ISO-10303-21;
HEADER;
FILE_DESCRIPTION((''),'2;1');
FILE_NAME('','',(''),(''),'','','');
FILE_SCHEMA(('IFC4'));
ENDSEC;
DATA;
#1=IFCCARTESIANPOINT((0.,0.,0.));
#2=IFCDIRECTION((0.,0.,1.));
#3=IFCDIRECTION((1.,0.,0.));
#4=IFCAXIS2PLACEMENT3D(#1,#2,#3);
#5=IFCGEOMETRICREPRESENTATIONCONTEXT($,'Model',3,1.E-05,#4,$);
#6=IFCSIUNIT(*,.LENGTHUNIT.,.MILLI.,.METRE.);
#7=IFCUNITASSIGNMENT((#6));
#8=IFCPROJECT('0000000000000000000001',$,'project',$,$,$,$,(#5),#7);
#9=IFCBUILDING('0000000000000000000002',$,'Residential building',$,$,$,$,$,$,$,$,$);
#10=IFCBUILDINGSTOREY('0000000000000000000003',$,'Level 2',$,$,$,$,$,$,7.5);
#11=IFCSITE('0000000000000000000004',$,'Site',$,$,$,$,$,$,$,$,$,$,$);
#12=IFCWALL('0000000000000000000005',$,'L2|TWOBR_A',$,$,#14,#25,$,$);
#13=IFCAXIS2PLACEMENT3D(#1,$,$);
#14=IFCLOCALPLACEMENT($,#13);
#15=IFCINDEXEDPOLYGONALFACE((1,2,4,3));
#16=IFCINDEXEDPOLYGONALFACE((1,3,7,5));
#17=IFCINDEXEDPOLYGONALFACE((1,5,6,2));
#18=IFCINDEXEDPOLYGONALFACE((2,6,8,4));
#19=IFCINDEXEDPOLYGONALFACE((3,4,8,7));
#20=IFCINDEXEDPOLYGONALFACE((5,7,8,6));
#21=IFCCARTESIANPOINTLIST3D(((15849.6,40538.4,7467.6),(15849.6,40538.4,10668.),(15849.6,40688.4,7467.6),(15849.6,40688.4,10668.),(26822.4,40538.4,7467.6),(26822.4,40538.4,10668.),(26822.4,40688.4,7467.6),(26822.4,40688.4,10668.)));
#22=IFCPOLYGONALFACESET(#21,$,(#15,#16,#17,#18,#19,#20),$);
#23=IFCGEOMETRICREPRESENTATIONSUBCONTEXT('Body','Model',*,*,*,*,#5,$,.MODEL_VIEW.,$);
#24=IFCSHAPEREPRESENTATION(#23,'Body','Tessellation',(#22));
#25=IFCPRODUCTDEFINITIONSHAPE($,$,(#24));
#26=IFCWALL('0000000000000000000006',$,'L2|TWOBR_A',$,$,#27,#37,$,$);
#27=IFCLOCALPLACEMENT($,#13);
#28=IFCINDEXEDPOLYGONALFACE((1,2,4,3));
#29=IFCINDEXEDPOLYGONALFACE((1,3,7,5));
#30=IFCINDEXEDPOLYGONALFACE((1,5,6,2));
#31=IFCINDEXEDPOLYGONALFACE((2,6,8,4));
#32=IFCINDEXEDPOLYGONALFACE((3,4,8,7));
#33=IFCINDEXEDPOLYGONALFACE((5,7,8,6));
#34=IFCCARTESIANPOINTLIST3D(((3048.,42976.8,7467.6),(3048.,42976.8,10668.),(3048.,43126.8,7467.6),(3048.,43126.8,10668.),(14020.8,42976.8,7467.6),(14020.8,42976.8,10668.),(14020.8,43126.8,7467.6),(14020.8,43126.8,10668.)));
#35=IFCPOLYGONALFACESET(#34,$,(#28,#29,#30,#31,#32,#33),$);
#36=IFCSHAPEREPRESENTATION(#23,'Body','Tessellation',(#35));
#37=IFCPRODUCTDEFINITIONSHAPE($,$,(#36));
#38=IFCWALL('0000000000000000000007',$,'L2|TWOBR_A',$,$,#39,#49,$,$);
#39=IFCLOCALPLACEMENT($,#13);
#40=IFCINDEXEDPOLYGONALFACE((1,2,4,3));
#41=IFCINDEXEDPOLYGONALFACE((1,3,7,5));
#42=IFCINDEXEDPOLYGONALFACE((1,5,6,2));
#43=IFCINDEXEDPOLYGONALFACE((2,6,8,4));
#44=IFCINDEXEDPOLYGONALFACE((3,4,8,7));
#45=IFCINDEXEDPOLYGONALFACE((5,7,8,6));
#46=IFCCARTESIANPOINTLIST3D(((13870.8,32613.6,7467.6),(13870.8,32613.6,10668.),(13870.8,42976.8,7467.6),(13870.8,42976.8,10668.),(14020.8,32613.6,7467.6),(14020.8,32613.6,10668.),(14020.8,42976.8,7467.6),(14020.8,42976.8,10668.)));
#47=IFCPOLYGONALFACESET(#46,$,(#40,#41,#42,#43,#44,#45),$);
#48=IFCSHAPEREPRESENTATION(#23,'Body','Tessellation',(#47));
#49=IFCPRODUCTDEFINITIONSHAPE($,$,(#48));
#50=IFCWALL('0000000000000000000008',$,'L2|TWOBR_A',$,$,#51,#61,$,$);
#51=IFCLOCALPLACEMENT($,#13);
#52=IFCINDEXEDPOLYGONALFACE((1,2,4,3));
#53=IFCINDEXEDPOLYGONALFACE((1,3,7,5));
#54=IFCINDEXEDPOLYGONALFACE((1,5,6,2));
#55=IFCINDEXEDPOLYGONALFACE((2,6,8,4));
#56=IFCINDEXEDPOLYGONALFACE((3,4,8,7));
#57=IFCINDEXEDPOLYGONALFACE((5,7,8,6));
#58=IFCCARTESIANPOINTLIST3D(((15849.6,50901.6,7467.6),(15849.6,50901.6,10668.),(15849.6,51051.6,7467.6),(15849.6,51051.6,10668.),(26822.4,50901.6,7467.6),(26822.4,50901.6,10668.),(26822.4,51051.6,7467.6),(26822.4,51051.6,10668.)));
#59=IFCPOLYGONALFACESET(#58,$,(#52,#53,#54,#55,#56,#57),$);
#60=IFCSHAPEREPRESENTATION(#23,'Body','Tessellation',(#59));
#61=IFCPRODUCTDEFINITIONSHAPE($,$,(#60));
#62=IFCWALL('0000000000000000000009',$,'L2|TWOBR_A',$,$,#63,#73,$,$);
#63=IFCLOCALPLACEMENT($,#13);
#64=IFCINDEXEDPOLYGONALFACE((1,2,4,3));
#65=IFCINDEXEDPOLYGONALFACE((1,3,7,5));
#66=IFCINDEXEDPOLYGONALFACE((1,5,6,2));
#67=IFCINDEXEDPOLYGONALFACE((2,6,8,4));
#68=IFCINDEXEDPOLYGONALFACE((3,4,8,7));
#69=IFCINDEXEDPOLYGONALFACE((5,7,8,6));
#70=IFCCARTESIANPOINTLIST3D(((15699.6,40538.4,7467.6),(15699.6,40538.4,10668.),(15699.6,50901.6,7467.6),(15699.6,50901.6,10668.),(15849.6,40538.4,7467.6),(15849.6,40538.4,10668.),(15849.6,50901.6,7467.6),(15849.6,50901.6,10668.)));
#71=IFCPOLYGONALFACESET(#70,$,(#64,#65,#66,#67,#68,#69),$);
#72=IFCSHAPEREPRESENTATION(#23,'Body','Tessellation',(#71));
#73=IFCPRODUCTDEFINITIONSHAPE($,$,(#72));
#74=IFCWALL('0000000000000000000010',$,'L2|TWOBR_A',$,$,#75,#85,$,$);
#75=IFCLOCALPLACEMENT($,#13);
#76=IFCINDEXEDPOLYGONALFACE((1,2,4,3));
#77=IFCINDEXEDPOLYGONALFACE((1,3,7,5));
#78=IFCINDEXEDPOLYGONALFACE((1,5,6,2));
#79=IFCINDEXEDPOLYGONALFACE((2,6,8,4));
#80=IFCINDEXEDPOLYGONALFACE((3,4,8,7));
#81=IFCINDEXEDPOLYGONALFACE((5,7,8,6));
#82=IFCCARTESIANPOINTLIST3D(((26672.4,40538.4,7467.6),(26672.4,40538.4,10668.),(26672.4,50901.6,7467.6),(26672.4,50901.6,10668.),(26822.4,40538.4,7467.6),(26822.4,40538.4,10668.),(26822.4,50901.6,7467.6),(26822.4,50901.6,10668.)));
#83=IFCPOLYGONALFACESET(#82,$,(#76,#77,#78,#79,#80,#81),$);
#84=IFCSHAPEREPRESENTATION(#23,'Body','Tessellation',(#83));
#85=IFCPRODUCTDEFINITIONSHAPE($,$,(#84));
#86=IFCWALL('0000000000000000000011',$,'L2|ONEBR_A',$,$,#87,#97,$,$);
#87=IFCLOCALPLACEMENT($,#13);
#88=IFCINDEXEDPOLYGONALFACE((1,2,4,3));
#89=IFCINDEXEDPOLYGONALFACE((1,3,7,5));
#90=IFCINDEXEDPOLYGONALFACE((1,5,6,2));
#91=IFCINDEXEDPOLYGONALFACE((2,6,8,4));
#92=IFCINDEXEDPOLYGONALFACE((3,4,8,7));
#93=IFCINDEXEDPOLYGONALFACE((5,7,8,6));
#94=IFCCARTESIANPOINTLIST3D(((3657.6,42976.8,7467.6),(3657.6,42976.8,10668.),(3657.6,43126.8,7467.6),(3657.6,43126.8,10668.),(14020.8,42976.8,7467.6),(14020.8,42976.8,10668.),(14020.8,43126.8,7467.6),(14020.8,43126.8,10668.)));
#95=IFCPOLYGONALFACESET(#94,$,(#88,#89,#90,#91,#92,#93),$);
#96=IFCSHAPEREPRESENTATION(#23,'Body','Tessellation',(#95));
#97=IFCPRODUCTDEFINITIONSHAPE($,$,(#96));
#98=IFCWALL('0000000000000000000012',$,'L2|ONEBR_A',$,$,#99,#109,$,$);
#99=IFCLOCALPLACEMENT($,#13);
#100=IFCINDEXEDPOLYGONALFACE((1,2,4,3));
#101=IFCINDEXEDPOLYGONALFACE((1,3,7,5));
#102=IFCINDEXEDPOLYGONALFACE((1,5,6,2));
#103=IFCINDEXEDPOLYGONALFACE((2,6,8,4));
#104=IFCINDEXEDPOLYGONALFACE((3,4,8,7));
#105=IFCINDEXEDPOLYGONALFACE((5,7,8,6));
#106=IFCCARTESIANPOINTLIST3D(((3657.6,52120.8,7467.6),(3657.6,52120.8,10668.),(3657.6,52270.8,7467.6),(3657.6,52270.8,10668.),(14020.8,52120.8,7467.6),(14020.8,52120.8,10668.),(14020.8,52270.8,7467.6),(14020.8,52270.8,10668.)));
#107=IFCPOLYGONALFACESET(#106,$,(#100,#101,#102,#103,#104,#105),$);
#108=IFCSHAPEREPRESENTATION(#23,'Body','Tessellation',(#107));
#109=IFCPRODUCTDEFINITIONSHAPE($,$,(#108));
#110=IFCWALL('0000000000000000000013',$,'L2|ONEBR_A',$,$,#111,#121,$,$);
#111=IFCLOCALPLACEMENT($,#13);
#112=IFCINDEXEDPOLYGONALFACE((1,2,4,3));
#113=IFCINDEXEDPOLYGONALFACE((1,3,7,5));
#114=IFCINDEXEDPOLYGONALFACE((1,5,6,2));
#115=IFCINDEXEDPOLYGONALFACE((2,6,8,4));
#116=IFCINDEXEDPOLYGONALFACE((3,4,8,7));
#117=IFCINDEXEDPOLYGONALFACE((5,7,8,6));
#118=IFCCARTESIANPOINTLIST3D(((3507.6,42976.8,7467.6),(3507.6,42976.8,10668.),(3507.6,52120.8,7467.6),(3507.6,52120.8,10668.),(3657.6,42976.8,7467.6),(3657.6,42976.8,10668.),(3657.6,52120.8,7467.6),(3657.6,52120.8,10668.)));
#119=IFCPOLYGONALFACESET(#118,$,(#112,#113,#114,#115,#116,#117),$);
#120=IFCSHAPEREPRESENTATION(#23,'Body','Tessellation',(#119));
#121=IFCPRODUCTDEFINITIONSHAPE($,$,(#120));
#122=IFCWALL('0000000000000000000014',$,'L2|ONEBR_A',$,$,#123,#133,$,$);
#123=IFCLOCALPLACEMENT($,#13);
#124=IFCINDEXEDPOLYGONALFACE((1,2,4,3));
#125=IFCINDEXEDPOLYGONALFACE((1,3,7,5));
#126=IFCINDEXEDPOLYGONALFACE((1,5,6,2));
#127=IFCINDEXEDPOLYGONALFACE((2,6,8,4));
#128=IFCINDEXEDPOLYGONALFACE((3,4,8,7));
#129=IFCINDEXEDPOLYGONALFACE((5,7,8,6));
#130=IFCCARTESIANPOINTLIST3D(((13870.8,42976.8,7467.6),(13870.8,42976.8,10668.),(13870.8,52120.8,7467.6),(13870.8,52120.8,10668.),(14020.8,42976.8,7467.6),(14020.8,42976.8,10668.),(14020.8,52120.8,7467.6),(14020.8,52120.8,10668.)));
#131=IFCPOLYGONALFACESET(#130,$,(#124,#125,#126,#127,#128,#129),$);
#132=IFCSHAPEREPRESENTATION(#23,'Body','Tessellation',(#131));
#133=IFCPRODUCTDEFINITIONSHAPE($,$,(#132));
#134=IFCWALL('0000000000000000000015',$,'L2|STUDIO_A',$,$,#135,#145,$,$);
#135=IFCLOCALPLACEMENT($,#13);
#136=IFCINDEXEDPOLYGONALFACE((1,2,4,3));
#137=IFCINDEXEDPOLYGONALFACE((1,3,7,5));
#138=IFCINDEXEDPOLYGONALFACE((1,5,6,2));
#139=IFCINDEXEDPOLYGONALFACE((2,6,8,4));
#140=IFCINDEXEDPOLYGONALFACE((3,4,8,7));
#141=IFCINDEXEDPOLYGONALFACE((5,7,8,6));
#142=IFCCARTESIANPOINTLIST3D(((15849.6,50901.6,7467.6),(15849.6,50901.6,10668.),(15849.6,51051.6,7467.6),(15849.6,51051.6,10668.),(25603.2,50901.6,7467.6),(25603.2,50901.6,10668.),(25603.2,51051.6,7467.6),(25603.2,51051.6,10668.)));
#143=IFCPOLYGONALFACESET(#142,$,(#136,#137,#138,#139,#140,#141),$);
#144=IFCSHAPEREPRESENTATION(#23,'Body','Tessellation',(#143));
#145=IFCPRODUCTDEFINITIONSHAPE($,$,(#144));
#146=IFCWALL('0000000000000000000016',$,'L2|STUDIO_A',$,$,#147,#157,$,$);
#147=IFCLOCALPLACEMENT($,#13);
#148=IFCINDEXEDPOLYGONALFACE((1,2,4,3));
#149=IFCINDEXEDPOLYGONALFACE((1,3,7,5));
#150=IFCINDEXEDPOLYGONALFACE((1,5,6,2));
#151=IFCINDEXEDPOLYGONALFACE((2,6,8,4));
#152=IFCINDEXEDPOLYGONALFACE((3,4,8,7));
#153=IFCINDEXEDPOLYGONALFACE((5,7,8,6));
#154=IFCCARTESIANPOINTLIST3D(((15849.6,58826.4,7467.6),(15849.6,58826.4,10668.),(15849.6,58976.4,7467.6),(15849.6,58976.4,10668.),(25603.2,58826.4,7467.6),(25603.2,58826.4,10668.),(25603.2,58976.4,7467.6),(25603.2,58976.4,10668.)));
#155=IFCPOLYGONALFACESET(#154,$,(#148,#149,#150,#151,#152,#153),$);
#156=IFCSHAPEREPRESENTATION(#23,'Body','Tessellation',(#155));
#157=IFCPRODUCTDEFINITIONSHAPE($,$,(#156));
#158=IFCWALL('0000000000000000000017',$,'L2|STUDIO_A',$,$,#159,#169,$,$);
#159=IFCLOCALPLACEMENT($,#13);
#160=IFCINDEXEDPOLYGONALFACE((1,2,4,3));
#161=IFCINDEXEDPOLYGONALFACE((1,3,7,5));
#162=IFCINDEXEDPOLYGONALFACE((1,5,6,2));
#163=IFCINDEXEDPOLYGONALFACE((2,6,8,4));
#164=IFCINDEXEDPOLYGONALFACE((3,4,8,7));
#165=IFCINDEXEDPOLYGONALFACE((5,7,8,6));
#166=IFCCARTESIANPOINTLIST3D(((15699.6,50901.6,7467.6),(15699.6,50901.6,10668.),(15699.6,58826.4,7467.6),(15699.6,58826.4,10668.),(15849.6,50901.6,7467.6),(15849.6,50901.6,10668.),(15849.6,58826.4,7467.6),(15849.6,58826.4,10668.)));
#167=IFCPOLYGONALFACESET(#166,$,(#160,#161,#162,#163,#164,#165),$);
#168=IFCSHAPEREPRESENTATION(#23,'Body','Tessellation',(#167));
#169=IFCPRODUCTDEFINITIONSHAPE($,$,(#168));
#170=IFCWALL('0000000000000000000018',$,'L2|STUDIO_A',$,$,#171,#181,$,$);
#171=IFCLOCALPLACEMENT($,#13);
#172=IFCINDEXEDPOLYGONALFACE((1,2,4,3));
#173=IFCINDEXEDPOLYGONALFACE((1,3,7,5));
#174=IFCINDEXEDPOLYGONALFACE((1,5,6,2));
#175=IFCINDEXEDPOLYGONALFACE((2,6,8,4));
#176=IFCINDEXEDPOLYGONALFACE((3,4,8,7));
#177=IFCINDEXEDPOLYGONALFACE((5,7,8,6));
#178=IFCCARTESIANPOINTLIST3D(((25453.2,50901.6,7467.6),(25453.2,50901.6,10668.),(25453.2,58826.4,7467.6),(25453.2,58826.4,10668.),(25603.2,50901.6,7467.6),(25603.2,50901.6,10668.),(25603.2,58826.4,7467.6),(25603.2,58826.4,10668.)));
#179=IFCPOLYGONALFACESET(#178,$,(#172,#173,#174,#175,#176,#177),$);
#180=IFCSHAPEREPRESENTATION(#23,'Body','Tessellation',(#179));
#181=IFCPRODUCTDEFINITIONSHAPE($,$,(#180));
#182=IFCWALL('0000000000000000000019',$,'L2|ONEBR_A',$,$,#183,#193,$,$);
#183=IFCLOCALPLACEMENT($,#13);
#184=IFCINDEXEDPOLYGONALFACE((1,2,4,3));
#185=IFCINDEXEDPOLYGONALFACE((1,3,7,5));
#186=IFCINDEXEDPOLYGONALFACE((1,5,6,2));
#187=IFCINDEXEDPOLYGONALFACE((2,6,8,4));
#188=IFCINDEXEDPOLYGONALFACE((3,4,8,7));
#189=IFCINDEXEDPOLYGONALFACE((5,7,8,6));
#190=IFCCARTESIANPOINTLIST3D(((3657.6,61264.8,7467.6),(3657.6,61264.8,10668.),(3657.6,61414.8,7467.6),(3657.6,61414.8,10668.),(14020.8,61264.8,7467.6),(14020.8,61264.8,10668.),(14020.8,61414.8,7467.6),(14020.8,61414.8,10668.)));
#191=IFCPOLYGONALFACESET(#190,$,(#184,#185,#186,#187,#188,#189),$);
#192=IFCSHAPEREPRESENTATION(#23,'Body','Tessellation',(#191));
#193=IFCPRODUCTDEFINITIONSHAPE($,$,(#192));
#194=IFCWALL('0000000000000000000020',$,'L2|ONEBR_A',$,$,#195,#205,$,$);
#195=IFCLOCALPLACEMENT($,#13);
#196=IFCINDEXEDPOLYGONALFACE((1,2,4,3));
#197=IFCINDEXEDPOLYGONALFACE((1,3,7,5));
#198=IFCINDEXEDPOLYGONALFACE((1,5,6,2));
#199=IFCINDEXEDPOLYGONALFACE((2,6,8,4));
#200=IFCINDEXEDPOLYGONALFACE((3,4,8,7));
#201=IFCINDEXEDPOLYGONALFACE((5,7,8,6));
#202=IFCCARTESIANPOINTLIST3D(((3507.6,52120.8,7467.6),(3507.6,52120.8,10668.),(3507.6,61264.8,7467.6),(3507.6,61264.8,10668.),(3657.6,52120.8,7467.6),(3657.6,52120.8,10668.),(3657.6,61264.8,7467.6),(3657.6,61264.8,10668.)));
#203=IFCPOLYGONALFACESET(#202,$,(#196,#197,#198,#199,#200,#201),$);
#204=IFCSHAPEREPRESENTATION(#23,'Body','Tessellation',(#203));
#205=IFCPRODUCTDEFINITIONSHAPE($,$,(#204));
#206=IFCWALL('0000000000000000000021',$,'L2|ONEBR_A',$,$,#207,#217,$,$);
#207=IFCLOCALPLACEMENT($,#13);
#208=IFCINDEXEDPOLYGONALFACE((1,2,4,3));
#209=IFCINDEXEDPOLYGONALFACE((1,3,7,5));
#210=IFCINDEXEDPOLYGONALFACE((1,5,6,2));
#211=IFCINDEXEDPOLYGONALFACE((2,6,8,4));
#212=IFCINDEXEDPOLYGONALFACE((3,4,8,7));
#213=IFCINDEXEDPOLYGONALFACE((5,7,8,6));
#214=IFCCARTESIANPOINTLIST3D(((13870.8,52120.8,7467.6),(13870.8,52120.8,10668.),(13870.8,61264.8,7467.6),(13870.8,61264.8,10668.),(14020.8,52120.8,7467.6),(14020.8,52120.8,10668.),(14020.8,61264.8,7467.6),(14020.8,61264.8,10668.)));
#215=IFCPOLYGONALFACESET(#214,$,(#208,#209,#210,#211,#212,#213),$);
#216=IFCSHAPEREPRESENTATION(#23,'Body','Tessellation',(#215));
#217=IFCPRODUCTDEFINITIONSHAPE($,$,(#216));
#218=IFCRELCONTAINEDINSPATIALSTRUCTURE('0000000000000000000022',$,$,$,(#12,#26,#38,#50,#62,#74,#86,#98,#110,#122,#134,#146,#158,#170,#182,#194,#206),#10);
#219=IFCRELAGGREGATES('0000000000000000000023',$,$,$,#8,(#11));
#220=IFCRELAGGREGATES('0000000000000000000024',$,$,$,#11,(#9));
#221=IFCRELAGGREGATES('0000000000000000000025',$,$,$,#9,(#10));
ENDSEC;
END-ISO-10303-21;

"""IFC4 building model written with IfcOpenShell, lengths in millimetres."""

from ifc_helpers import new_model, si_unit, frame, origin_with_axes, place, context, subcontext, project, spatial, indexed_curve, outline, extrude, element, save


model = new_model("IFC4")

# Units and contexts
model_context = context("Model", 3, precision=1e-05, world=origin_with_axes())
body_context = subcontext(model_context, "Body", "Model", "MODEL_VIEW")
ifc_project = project(units=[si_unit("LENGTHUNIT", "METRE", prefix="MILLI")], contexts=[model_context])

# Site, building, storey
site = spatial("IfcSite", under=ifc_project, Name="Site")
building = spatial("IfcBuilding", under=site, Name="Residential building")
storey = spatial("IfcBuildingStorey", under=building, Name="Level 2", Elevation=7.5)

# Walls
for number, where, z_axis, x_axis, name in (
    (1, (15849.6, 40538.4, 7467.6), (0.0, 0.0, 1.0), (1.0, 0.0, 0.0), "L2|TWOBR_A"),
    (2, (3048.0, 42976.8, 7467.6), (0.0, 0.0, 1.0), (1.0, 0.0, 0.0), "L2|TWOBR_A"),
):
    element("IfcWall", number, at=place(None, frame(where, z_axis=z_axis, x_axis=x_axis)), inside=storey, Name=name, context=body_context, shape_type="SweptSolid", body=[
        extrude(outline(indexed_curve([(0.0, 0.0), (0.0, 150.0), (10972.8, 150.0), (10972.8, 0.0), (0.0, 0.0)], self_intersect=False)), origin_with_axes(), (0.0, 0.0, 1.0), 3200.4),
    ])
wall_placement = place(None, frame((14020.8, 32613.6, 7467.6), z_axis=(0.0, 0.0, 1.0), x_axis=(0.0, 1.0, 0.0)))
element("IfcWall", 3, at=wall_placement, inside=storey, Name="L2|TWOBR_A", context=body_context, shape_type="SweptSolid", body=[
    extrude(outline(indexed_curve([(0.0, 0.0), (0.0, 150.0), (10363.2, 150.0), (10363.2, 0.0), (0.0, 0.0)], self_intersect=False)), origin_with_axes(), (0.0, 0.0, 1.0), 3200.4),
])
for number, where, z_axis, x_axis, name in (
    (4, (15849.6, 50901.6, 7467.6), (0.0, 0.0, 1.0), (1.0, 0.0, 0.0), "L2|TWOBR_A"),
):
    element("IfcWall", number, at=place(None, frame(where, z_axis=z_axis, x_axis=x_axis)), inside=storey, Name=name, context=body_context, shape_type="SweptSolid", body=[
        extrude(outline(indexed_curve([(0.0, 0.0), (0.0, 150.0), (10972.8, 150.0), (10972.8, 0.0), (0.0, 0.0)], self_intersect=False)), origin_with_axes(), (0.0, 0.0, 1.0), 3200.4),
    ])
for number, where, z_axis, x_axis, name in (
    (5, (15849.6, 40538.4, 7467.6), (0.0, 0.0, 1.0), (0.0, 1.0, 0.0), "L2|TWOBR_A"),
    (6, (26822.4, 40538.4, 7467.6), (0.0, 0.0, 1.0), (0.0, 1.0, 0.0), "L2|TWOBR_A"),
    (7, (3657.6, 42976.8, 7467.6), (0.0, 0.0, 1.0), (1.0, 0.0, 0.0), "L2|ONEBR_A"),
    (8, (3657.6, 52120.8, 7467.6), (0.0, 0.0, 1.0), (1.0, 0.0, 0.0), "L2|ONEBR_A"),
):
    element("IfcWall", number, at=place(None, frame(where, z_axis=z_axis, x_axis=x_axis)), inside=storey, Name=name, context=body_context, shape_type="SweptSolid", body=[
        extrude(outline(indexed_curve([(0.0, 0.0), (0.0, 150.0), (10363.2, 150.0), (10363.2, 0.0), (0.0, 0.0)], self_intersect=False)), origin_with_axes(), (0.0, 0.0, 1.0), 3200.4),
    ])
for number, where, z_axis, x_axis, name in (
    (9, (3657.6, 42976.8, 7467.6), (0.0, 0.0, 1.0), (0.0, 1.0, 0.0), "L2|ONEBR_A"),
    (10, (14020.8, 42976.8, 7467.6), (0.0, 0.0, 1.0), (0.0, 1.0, 0.0), "L2|ONEBR_A"),
):
    element("IfcWall", number, at=place(None, frame(where, z_axis=z_axis, x_axis=x_axis)), inside=storey, Name=name, context=body_context, shape_type="SweptSolid", body=[
        extrude(outline(indexed_curve([(0.0, 0.0), (0.0, 150.0), (9144.0, 150.0), (9144.0, 0.0), (0.0, 0.0)], self_intersect=False)), origin_with_axes(), (0.0, 0.0, 1.0), 3200.4),
    ])
for number, where, z_axis, x_axis, name in (
    (11, (15849.6, 50901.6, 7467.6), (0.0, 0.0, 1.0), (1.0, 0.0, 0.0), "L2|STUDIO_A"),
    (12, (15849.6, 58826.4, 7467.6), (0.0, 0.0, 1.0), (1.0, 0.0, 0.0), "L2|STUDIO_A"),
):
    element("IfcWall", number, at=place(None, frame(where, z_axis=z_axis, x_axis=x_axis)), inside=storey, Name=name, context=body_context, shape_type="SweptSolid", body=[
        extrude(outline(indexed_curve([(0.0, 0.0), (0.0, 150.0), (9753.6, 150.0), (9753.6, 0.0), (0.0, 0.0)], self_intersect=False)), origin_with_axes(), (0.0, 0.0, 1.0), 3200.4),
    ])
for number, where, z_axis, x_axis, name in (
    (13, (15849.6, 50901.6, 7467.6), (0.0, 0.0, 1.0), (0.0, 1.0, 0.0), "L2|STUDIO_A"),
    (14, (25603.2, 50901.6, 7467.6), (0.0, 0.0, 1.0), (0.0, 1.0, 0.0), "L2|STUDIO_A"),
):
    element("IfcWall", number, at=place(None, frame(where, z_axis=z_axis, x_axis=x_axis)), inside=storey, Name=name, context=body_context, shape_type="SweptSolid", body=[
        extrude(outline(indexed_curve([(0.0, 0.0), (0.0, 150.0), (7924.8, 150.0), (7924.8, 0.0), (0.0, 0.0)], self_intersect=False)), origin_with_axes(), (0.0, 0.0, 1.0), 3200.4),
    ])
for number, where, z_axis, x_axis, name in (
    (15, (3657.6, 61264.8, 7467.6), (0.0, 0.0, 1.0), (1.0, 0.0, 0.0), "L2|ONEBR_A"),
):
    element("IfcWall", number, at=place(None, frame(where, z_axis=z_axis, x_axis=x_axis)), inside=storey, Name=name, context=body_context, shape_type="SweptSolid", body=[
        extrude(outline(indexed_curve([(0.0, 0.0), (0.0, 150.0), (10363.2, 150.0), (10363.2, 0.0), (0.0, 0.0)], self_intersect=False)), origin_with_axes(), (0.0, 0.0, 1.0), 3200.4),
    ])
for number, where, z_axis, x_axis, name in (
    (16, (3657.6, 52120.8, 7467.6), (0.0, 0.0, 1.0), (0.0, 1.0, 0.0), "L2|ONEBR_A"),
    (17, (14020.8, 52120.8, 7467.6), (0.0, 0.0, 1.0), (0.0, 1.0, 0.0), "L2|ONEBR_A"),
):
    element("IfcWall", number, at=place(None, frame(where, z_axis=z_axis, x_axis=x_axis)), inside=storey, Name=name, context=body_context, shape_type="SweptSolid", body=[
        extrude(outline(indexed_curve([(0.0, 0.0), (0.0, 150.0), (9144.0, 150.0), (9144.0, 0.0), (0.0, 0.0)], self_intersect=False)), origin_with_axes(), (0.0, 0.0, 1.0), 3200.4),
    ])

save(model, "model.ifc")
